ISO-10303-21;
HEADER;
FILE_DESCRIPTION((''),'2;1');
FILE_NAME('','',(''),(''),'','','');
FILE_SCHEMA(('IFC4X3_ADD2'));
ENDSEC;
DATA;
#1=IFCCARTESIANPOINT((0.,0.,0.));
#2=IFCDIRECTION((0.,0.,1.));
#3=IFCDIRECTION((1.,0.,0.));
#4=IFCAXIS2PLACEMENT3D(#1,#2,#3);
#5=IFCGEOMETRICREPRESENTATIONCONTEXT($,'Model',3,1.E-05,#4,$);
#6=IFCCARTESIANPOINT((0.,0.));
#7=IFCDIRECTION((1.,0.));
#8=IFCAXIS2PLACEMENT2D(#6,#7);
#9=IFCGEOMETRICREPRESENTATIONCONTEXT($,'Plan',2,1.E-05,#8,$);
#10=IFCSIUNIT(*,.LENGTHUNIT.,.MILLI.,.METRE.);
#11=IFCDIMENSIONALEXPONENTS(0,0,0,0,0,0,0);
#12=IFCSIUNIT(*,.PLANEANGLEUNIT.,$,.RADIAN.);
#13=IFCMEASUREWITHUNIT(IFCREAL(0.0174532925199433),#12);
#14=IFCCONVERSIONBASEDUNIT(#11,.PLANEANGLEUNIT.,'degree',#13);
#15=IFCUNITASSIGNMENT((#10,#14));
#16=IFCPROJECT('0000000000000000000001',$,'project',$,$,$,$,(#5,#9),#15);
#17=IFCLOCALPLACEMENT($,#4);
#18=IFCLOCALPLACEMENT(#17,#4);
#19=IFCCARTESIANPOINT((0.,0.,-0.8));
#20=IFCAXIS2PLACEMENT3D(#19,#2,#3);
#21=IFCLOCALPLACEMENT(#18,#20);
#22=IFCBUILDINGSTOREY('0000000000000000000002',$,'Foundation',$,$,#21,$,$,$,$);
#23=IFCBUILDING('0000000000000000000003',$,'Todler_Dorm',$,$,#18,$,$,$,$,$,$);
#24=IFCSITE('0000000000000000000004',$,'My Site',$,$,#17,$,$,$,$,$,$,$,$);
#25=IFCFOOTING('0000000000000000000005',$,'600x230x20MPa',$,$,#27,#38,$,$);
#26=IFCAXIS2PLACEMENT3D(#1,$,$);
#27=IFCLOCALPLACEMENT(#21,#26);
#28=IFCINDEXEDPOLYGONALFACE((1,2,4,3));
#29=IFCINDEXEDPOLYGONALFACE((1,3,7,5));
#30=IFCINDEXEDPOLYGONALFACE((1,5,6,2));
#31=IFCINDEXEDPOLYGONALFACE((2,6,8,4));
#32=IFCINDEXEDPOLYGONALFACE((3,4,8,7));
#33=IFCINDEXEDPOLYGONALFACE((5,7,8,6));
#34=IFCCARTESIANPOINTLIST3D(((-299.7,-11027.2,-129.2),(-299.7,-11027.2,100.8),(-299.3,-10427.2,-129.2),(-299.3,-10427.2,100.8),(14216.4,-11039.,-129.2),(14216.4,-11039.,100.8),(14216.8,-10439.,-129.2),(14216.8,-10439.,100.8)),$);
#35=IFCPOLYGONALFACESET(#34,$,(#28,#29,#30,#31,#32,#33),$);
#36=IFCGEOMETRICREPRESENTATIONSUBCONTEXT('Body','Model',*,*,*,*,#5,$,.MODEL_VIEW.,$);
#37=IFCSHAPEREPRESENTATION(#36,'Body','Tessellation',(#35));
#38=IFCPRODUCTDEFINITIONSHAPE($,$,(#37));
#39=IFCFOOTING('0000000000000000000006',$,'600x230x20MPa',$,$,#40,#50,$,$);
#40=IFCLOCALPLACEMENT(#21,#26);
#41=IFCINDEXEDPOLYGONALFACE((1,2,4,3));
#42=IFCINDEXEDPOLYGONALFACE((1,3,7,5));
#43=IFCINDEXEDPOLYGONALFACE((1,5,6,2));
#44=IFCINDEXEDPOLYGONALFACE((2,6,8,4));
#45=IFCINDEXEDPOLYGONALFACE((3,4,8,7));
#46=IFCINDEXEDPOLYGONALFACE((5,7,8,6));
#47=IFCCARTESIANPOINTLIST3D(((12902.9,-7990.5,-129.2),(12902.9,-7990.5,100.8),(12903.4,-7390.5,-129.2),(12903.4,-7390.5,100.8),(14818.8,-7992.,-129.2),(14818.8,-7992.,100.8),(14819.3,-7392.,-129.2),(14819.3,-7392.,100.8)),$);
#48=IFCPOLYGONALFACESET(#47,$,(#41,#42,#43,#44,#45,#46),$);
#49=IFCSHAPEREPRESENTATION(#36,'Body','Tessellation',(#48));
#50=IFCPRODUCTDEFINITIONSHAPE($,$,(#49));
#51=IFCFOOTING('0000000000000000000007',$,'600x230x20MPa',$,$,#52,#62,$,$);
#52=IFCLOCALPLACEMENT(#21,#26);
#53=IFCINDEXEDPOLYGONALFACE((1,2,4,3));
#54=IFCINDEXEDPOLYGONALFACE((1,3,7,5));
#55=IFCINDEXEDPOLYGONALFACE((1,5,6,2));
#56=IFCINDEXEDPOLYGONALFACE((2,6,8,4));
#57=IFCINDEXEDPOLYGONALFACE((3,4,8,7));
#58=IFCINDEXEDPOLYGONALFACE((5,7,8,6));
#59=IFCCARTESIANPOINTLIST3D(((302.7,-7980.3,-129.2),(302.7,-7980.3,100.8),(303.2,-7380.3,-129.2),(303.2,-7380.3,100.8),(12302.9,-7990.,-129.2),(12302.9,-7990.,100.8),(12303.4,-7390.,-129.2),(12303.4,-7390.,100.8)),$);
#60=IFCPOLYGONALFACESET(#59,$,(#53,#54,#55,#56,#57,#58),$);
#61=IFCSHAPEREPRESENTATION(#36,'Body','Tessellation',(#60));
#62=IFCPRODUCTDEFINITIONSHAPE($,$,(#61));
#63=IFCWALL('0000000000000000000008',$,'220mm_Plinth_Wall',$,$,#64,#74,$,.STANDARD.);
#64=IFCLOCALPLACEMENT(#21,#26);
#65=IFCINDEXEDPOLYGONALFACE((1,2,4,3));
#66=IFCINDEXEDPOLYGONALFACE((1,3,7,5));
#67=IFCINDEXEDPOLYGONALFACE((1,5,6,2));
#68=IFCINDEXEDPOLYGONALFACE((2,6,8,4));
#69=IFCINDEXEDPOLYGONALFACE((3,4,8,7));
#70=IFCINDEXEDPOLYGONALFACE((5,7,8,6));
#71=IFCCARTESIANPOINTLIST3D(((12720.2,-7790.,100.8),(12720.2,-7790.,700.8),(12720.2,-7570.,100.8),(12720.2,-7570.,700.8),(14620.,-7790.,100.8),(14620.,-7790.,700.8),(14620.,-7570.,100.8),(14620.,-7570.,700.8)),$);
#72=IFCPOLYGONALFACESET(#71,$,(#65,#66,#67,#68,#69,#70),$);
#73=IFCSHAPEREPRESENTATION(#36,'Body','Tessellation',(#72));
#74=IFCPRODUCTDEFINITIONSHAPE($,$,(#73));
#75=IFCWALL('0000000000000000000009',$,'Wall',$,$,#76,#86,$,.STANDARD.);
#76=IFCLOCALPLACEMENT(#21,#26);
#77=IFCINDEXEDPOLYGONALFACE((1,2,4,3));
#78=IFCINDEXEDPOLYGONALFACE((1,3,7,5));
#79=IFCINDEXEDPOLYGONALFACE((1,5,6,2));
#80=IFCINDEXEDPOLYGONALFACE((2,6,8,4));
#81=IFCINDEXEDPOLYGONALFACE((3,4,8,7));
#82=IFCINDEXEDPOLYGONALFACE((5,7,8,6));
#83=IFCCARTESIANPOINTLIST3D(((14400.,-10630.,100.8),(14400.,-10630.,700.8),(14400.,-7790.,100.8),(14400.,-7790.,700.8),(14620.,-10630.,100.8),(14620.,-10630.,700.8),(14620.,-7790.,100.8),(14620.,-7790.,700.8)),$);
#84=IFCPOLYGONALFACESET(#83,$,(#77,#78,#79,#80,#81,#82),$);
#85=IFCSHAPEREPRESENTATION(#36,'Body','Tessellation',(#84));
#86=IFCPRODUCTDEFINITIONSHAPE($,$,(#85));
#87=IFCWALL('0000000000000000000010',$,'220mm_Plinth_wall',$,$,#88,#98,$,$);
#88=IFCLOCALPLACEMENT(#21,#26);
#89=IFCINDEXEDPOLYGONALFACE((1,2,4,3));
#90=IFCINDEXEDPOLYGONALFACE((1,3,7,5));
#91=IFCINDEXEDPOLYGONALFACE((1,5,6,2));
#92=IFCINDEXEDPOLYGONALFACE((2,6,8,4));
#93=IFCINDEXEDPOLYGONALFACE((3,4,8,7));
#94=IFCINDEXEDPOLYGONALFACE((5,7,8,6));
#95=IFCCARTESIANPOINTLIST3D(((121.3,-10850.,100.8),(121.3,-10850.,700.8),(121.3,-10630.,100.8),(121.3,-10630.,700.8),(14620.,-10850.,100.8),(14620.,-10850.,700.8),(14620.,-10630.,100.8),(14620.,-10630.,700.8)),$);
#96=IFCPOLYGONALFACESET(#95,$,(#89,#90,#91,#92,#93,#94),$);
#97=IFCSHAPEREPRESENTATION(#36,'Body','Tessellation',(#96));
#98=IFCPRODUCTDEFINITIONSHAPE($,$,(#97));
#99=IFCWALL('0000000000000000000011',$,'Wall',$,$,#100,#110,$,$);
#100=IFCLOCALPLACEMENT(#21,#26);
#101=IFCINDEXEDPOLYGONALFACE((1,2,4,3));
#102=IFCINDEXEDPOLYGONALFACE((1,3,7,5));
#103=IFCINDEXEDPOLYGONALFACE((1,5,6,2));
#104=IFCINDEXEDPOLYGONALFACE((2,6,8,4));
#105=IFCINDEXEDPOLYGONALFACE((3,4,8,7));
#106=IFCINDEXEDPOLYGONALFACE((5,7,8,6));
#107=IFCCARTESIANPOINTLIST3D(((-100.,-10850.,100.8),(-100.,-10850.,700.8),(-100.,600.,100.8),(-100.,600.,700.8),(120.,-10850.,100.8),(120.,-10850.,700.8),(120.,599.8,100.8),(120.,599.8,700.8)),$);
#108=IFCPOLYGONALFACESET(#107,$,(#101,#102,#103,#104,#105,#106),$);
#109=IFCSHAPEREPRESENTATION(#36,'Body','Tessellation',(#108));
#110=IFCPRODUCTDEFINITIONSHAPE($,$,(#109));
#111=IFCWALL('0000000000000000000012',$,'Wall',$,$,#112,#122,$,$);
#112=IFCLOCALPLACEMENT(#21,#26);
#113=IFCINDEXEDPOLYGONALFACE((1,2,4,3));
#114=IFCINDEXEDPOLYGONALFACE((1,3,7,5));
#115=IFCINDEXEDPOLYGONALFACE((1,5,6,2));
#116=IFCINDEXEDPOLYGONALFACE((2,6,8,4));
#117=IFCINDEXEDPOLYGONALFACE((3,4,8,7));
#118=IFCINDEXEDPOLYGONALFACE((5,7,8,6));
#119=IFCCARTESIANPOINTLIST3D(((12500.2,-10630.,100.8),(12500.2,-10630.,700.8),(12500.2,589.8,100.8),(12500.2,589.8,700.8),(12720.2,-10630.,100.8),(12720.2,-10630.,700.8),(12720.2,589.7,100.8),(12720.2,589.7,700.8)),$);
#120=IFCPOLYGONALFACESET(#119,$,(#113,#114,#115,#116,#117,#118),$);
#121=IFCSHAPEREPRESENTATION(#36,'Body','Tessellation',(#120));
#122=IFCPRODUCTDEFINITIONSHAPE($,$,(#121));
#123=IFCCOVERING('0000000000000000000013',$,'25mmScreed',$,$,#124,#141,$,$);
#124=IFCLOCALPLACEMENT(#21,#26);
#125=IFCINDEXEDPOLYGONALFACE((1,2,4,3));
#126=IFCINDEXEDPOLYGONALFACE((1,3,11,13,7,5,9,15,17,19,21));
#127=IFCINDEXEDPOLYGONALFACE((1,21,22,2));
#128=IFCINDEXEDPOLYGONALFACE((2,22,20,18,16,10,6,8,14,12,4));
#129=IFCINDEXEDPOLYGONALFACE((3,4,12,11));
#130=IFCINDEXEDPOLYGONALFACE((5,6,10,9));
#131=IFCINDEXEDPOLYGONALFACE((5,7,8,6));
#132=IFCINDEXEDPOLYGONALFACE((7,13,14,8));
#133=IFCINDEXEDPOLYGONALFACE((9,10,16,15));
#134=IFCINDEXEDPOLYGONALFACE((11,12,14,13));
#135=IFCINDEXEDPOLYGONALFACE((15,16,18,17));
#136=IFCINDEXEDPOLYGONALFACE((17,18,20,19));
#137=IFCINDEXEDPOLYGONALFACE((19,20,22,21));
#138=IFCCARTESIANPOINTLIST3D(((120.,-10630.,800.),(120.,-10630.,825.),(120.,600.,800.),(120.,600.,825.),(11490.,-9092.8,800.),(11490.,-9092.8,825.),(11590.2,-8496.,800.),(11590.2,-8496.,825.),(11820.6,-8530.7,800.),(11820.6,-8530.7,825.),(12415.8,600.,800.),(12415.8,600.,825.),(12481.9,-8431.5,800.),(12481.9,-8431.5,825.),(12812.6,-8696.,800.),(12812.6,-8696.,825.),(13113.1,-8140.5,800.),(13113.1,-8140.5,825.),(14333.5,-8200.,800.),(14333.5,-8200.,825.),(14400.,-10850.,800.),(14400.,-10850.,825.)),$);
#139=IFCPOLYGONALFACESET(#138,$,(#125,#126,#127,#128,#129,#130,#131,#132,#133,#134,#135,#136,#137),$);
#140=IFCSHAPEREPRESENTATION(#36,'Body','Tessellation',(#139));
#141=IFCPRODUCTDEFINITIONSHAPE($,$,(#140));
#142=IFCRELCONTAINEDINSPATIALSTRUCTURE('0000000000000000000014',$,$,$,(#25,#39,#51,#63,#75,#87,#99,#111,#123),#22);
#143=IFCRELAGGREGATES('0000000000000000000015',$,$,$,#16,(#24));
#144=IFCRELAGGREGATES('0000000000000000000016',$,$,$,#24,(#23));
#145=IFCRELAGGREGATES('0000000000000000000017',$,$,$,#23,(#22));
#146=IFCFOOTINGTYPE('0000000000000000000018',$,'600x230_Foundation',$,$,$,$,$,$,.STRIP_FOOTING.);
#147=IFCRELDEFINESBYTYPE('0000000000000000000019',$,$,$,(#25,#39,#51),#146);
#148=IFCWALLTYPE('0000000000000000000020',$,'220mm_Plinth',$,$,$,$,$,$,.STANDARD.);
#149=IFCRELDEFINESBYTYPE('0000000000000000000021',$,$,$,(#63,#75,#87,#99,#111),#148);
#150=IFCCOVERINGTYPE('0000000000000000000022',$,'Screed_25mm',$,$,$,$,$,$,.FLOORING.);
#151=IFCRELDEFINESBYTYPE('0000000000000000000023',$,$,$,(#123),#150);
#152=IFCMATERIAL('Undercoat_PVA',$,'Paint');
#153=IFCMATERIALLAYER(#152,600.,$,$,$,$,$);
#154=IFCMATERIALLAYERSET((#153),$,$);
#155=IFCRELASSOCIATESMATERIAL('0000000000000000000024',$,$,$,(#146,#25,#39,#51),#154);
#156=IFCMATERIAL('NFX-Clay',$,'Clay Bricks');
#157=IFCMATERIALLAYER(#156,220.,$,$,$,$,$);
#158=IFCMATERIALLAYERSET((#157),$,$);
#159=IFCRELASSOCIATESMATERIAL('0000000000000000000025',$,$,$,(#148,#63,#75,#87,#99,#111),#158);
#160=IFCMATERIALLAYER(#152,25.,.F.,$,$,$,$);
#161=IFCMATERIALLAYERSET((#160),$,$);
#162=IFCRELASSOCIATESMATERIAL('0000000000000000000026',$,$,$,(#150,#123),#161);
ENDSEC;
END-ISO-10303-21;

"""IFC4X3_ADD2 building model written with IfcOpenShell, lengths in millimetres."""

from ifc_helpers import new_model, entity, si_unit, converted_unit, frame, origin_with_axes, origin_2d_with_axis, place, context, subcontext, project, spatial, line, indexed_curve, outline, extrude, material, layer, layer_set, layer_usage, type_object, element, save


model = new_model("IFC4X3_ADD2")

# Units and contexts
model_context = context("Model", 3, precision=1e-05, world=origin_with_axes())
plan_context = context("Plan", 2, precision=1e-05, world=origin_2d_with_axis())
body_context = subcontext(model_context, "Body", "Model", "MODEL_VIEW")
ifc_project = project(units=[si_unit("LENGTHUNIT", "METRE", prefix="MILLI"), converted_unit("PLANEANGLEUNIT", "degree", entity("IfcReal", 0.0174532925199433), si_unit("PLANEANGLEUNIT", "RADIAN"), dimensions=[0, 0, 0, 0, 0, 0, 0])], contexts=[model_context, plan_context])

# Site, building, storey
site_placement = place(None, origin_with_axes())
site = spatial("IfcSite", under=ifc_project, at=site_placement, Name="My Site")
building_placement = place(site_placement, origin_with_axes())
building = spatial("IfcBuilding", under=site, at=building_placement, Name="Todler_Dorm")
storey_placement = place(building_placement, frame((0.0, 0.0, -0.8), z_axis=(0.0, 0.0, 1.0), x_axis=(1.0, 0.0, 0.0)))
storey = spatial("IfcBuildingStorey", under=building, at=storey_placement, Name="Foundation")

# Footings
ifc_material_1 = material(Name="Undercoat_PVA", Category="Paint")
ifc_layer_1 = layer(ifc_material_1, 600.0)
ifc_layer_set_1 = layer_set([ifc_layer_1])
ifc_layer_usage_1 = layer_usage(ifc_layer_set_1, "AXIS2", "POSITIVE", 0.0)
footing_type = type_object("IfcFootingType", Name="600x230_Foundation", PredefinedType="STRIP_FOOTING", material=ifc_layer_set_1)
footing_1_placement = place(storey_placement, frame((14216.8, -10439.0, -129.2), z_axis=(0.0, 0.0, 1.0), x_axis=(-1.0, 0.000807, 0.0)))
element("IfcFooting", 1, at=footing_1_placement, inside=storey, type_object=footing_type, material=ifc_layer_usage_1, Name="600x230x20MPa", context=body_context, shape_type="SweptSolid", body=[
    extrude(outline(indexed_curve([(0.0, 0.0), (0.0, 600.0), (14516.1, 600.0), (14516.1, 0.0)], segments=[line(1, 2, 3, 4, 1)])), origin_with_axes(), (0.0, 0.0, 1.0), 230.0),
])
ifc_layer_usage_2 = layer_usage(ifc_layer_set_1, "AXIS2", "POSITIVE", 0.0)
footing_2_placement = place(storey_placement, frame((14819.3, -7392.0, -129.2), z_axis=(0.0, 0.0, 1.0), x_axis=(-1.0, 0.000807, 0.0)))
element("IfcFooting", 2, at=footing_2_placement, inside=storey, type_object=footing_type, material=ifc_layer_usage_2, Name="600x230x20MPa", context=body_context, shape_type="SweptSolid", body=[
    extrude(outline(indexed_curve([(0.0, 0.0), (0.0, 600.0), (1915.9, 600.0), (1915.9, 0.0)], segments=[line(1, 2, 3, 4, 1)])), origin_with_axes(), (0.0, 0.0, 1.0), 230.0),
])
ifc_layer_usage_3 = layer_usage(ifc_layer_set_1, "AXIS2", "POSITIVE", 0.0)
footing_3_placement = place(storey_placement, frame((12303.4, -7390.0, -129.2), z_axis=(0.0, 0.0, 1.0), x_axis=(-1.0, 0.000807, 0.0)))
element("IfcFooting", 3, at=footing_3_placement, inside=storey, type_object=footing_type, material=ifc_layer_usage_3, Name="600x230x20MPa", context=body_context, shape_type="SweptSolid", body=[
    extrude(outline(indexed_curve([(0.0, 0.0), (0.0, 600.0), (12000.2, 600.0), (12000.2, 0.0)], segments=[line(1, 2, 3, 4, 1)])), origin_with_axes(), (0.0, 0.0, 1.0), 230.0),
])

# Walls
ifc_material_2 = material(Name="NFX-Clay", Category="Clay Bricks")
ifc_layer_2 = layer(ifc_material_2, 220.0)
ifc_layer_set_2 = layer_set([ifc_layer_2])
ifc_layer_usage_4 = layer_usage(ifc_layer_set_2, "AXIS2", "POSITIVE", 0.0)
wall_type = type_object("IfcWallType", Name="220mm_Plinth", PredefinedType="STANDARD", material=ifc_layer_set_2)
wall_1_placement = place(storey_placement, frame((12720.2, -7790.0, 100.8), z_axis=(0.0, 0.0, 1.0), x_axis=(1.0, 0.0, 0.0)))
element("IfcWall", 4, at=wall_1_placement, inside=storey, type_object=wall_type, material=ifc_layer_usage_4, Name="220mm_Plinth_Wall", PredefinedType="STANDARD", context=body_context, shape_type="SweptSolid", body=[
    extrude(outline(indexed_curve([(0.0, 0.0), (0.0, 220.0), (1899.8, 220.0), (1899.8, 0.0)], segments=[line(1, 2, 3, 4, 1)])), origin_with_axes(), (0.0, 0.0, 1.0), 600.0),
])
ifc_layer_usage_5 = layer_usage(ifc_layer_set_2, "AXIS2", "POSITIVE", 0.0)
wall_2_placement = place(storey_placement, frame((14400.0, -7790.0, 100.8), z_axis=(0.0, 0.0, 1.0), x_axis=(0.0, -1.0, 0.0)))
element("IfcWall", 5, at=wall_2_placement, inside=storey, type_object=wall_type, material=ifc_layer_usage_5, Name="Wall", PredefinedType="STANDARD", context=body_context, shape_type="SweptSolid", body=[
    extrude(outline(indexed_curve([(0.0, 0.0), (0.0, 220.0), (2840.0, 220.0), (2840.0, 0.0)], segments=[line(1, 2, 3, 4, 1)])), origin_with_axes(), (0.0, 0.0, 1.0), 600.0),
])
ifc_layer_usage_6 = layer_usage(ifc_layer_set_2, "AXIS2", "POSITIVE", 0.0)
wall_3_placement = place(storey_placement, frame((14620.0, -10630.0, 100.8), z_axis=(0.0, 0.0, 1.0), x_axis=(-1.0, 0.0, 0.0)))
element("IfcWall", 6, at=wall_3_placement, inside=storey, type_object=wall_type, material=ifc_layer_usage_6, Name="220mm_Plinth_wall", context=body_context, shape_type="SweptSolid", body=[
    extrude(outline(indexed_curve([(0.0, 0.0), (0.0, 220.0), (14498.7, 220.0), (14498.7, 0.0)], segments=[line(1, 2, 3, 4, 1)])), origin_with_axes(), (0.0, 0.0, 1.0), 600.0),
])
ifc_layer_usage_7 = layer_usage(ifc_layer_set_2, "AXIS2", "POSITIVE", 0.0)
wall_4_placement = place(storey_placement, frame((120.0, -10850.0, 100.8), z_axis=(0.0, 0.0, 1.0), x_axis=(0.0, 1.0, 0.0)))
element("IfcWall", 7, at=wall_4_placement, inside=storey, type_object=wall_type, material=ifc_layer_usage_7, Name="Wall", context=body_context, shape_type="SweptSolid", body=[
    extrude(outline(indexed_curve([(0.0, 0.0), (0.0, 220.0), (11450.0, 220.0), (11449.8, 0.0)], segments=[line(1, 2, 3, 4, 1)])), origin_with_axes(), (0.0, 0.0, 1.0), 600.0),
])
ifc_layer_usage_8 = layer_usage(ifc_layer_set_2, "AXIS2", "POSITIVE", 0.0)
wall_5_placement = place(storey_placement, frame((12720.2, -10630.0, 100.8), z_axis=(0.0, 0.0, 1.0), x_axis=(0.0, 1.0, 0.0)))
element("IfcWall", 8, at=wall_5_placement, inside=storey, type_object=wall_type, material=ifc_layer_usage_8, Name="Wall", context=body_context, shape_type="SweptSolid", body=[
    extrude(outline(indexed_curve([(0.0, 0.0), (0.0, 220.0), (11219.8, 220.0), (11219.7, 0.0)], segments=[line(1, 2, 3, 4, 1)])), origin_with_axes(), (0.0, 0.0, 1.0), 600.0),
])

# Covering
ifc_layer_3 = layer(ifc_material_1, 25.0, ventilated=False)
ifc_layer_set_3 = layer_set([ifc_layer_3])
ifc_layer_usage_9 = layer_usage(ifc_layer_set_3, "AXIS3", "POSITIVE", 0.0)
covering_type = type_object("IfcCoveringType", Name="Screed_25mm", PredefinedType="FLOORING", material=ifc_layer_set_3)
covering_placement = place(storey_placement, frame((120.0, -10630.0, 800.0), z_axis=(0.0, 0.0, 1.0), x_axis=(1.0, 0.0, 0.0)))
element("IfcCovering", 9, at=covering_placement, inside=storey, type_object=covering_type, material=ifc_layer_usage_9, Name="25mmScreed", context=body_context, shape_type="SweptSolid", body=[
    extrude(outline(indexed_curve([(0.0, 0.0), (0.0, 11230.0), (12295.8, 11230.0), (12361.9, 2198.5), (11470.2, 2134.0), (11370.0, 1537.2), (11700.6, 2099.3), (12692.6, 1934.0), (12993.1, 2489.5), (14213.5, 2430.0), (14280.0, -220.0), (0.0, 0.0)])), None, (0.0, 0.0, 1.0), 25.0),
])

save(model, "model.ifc")
